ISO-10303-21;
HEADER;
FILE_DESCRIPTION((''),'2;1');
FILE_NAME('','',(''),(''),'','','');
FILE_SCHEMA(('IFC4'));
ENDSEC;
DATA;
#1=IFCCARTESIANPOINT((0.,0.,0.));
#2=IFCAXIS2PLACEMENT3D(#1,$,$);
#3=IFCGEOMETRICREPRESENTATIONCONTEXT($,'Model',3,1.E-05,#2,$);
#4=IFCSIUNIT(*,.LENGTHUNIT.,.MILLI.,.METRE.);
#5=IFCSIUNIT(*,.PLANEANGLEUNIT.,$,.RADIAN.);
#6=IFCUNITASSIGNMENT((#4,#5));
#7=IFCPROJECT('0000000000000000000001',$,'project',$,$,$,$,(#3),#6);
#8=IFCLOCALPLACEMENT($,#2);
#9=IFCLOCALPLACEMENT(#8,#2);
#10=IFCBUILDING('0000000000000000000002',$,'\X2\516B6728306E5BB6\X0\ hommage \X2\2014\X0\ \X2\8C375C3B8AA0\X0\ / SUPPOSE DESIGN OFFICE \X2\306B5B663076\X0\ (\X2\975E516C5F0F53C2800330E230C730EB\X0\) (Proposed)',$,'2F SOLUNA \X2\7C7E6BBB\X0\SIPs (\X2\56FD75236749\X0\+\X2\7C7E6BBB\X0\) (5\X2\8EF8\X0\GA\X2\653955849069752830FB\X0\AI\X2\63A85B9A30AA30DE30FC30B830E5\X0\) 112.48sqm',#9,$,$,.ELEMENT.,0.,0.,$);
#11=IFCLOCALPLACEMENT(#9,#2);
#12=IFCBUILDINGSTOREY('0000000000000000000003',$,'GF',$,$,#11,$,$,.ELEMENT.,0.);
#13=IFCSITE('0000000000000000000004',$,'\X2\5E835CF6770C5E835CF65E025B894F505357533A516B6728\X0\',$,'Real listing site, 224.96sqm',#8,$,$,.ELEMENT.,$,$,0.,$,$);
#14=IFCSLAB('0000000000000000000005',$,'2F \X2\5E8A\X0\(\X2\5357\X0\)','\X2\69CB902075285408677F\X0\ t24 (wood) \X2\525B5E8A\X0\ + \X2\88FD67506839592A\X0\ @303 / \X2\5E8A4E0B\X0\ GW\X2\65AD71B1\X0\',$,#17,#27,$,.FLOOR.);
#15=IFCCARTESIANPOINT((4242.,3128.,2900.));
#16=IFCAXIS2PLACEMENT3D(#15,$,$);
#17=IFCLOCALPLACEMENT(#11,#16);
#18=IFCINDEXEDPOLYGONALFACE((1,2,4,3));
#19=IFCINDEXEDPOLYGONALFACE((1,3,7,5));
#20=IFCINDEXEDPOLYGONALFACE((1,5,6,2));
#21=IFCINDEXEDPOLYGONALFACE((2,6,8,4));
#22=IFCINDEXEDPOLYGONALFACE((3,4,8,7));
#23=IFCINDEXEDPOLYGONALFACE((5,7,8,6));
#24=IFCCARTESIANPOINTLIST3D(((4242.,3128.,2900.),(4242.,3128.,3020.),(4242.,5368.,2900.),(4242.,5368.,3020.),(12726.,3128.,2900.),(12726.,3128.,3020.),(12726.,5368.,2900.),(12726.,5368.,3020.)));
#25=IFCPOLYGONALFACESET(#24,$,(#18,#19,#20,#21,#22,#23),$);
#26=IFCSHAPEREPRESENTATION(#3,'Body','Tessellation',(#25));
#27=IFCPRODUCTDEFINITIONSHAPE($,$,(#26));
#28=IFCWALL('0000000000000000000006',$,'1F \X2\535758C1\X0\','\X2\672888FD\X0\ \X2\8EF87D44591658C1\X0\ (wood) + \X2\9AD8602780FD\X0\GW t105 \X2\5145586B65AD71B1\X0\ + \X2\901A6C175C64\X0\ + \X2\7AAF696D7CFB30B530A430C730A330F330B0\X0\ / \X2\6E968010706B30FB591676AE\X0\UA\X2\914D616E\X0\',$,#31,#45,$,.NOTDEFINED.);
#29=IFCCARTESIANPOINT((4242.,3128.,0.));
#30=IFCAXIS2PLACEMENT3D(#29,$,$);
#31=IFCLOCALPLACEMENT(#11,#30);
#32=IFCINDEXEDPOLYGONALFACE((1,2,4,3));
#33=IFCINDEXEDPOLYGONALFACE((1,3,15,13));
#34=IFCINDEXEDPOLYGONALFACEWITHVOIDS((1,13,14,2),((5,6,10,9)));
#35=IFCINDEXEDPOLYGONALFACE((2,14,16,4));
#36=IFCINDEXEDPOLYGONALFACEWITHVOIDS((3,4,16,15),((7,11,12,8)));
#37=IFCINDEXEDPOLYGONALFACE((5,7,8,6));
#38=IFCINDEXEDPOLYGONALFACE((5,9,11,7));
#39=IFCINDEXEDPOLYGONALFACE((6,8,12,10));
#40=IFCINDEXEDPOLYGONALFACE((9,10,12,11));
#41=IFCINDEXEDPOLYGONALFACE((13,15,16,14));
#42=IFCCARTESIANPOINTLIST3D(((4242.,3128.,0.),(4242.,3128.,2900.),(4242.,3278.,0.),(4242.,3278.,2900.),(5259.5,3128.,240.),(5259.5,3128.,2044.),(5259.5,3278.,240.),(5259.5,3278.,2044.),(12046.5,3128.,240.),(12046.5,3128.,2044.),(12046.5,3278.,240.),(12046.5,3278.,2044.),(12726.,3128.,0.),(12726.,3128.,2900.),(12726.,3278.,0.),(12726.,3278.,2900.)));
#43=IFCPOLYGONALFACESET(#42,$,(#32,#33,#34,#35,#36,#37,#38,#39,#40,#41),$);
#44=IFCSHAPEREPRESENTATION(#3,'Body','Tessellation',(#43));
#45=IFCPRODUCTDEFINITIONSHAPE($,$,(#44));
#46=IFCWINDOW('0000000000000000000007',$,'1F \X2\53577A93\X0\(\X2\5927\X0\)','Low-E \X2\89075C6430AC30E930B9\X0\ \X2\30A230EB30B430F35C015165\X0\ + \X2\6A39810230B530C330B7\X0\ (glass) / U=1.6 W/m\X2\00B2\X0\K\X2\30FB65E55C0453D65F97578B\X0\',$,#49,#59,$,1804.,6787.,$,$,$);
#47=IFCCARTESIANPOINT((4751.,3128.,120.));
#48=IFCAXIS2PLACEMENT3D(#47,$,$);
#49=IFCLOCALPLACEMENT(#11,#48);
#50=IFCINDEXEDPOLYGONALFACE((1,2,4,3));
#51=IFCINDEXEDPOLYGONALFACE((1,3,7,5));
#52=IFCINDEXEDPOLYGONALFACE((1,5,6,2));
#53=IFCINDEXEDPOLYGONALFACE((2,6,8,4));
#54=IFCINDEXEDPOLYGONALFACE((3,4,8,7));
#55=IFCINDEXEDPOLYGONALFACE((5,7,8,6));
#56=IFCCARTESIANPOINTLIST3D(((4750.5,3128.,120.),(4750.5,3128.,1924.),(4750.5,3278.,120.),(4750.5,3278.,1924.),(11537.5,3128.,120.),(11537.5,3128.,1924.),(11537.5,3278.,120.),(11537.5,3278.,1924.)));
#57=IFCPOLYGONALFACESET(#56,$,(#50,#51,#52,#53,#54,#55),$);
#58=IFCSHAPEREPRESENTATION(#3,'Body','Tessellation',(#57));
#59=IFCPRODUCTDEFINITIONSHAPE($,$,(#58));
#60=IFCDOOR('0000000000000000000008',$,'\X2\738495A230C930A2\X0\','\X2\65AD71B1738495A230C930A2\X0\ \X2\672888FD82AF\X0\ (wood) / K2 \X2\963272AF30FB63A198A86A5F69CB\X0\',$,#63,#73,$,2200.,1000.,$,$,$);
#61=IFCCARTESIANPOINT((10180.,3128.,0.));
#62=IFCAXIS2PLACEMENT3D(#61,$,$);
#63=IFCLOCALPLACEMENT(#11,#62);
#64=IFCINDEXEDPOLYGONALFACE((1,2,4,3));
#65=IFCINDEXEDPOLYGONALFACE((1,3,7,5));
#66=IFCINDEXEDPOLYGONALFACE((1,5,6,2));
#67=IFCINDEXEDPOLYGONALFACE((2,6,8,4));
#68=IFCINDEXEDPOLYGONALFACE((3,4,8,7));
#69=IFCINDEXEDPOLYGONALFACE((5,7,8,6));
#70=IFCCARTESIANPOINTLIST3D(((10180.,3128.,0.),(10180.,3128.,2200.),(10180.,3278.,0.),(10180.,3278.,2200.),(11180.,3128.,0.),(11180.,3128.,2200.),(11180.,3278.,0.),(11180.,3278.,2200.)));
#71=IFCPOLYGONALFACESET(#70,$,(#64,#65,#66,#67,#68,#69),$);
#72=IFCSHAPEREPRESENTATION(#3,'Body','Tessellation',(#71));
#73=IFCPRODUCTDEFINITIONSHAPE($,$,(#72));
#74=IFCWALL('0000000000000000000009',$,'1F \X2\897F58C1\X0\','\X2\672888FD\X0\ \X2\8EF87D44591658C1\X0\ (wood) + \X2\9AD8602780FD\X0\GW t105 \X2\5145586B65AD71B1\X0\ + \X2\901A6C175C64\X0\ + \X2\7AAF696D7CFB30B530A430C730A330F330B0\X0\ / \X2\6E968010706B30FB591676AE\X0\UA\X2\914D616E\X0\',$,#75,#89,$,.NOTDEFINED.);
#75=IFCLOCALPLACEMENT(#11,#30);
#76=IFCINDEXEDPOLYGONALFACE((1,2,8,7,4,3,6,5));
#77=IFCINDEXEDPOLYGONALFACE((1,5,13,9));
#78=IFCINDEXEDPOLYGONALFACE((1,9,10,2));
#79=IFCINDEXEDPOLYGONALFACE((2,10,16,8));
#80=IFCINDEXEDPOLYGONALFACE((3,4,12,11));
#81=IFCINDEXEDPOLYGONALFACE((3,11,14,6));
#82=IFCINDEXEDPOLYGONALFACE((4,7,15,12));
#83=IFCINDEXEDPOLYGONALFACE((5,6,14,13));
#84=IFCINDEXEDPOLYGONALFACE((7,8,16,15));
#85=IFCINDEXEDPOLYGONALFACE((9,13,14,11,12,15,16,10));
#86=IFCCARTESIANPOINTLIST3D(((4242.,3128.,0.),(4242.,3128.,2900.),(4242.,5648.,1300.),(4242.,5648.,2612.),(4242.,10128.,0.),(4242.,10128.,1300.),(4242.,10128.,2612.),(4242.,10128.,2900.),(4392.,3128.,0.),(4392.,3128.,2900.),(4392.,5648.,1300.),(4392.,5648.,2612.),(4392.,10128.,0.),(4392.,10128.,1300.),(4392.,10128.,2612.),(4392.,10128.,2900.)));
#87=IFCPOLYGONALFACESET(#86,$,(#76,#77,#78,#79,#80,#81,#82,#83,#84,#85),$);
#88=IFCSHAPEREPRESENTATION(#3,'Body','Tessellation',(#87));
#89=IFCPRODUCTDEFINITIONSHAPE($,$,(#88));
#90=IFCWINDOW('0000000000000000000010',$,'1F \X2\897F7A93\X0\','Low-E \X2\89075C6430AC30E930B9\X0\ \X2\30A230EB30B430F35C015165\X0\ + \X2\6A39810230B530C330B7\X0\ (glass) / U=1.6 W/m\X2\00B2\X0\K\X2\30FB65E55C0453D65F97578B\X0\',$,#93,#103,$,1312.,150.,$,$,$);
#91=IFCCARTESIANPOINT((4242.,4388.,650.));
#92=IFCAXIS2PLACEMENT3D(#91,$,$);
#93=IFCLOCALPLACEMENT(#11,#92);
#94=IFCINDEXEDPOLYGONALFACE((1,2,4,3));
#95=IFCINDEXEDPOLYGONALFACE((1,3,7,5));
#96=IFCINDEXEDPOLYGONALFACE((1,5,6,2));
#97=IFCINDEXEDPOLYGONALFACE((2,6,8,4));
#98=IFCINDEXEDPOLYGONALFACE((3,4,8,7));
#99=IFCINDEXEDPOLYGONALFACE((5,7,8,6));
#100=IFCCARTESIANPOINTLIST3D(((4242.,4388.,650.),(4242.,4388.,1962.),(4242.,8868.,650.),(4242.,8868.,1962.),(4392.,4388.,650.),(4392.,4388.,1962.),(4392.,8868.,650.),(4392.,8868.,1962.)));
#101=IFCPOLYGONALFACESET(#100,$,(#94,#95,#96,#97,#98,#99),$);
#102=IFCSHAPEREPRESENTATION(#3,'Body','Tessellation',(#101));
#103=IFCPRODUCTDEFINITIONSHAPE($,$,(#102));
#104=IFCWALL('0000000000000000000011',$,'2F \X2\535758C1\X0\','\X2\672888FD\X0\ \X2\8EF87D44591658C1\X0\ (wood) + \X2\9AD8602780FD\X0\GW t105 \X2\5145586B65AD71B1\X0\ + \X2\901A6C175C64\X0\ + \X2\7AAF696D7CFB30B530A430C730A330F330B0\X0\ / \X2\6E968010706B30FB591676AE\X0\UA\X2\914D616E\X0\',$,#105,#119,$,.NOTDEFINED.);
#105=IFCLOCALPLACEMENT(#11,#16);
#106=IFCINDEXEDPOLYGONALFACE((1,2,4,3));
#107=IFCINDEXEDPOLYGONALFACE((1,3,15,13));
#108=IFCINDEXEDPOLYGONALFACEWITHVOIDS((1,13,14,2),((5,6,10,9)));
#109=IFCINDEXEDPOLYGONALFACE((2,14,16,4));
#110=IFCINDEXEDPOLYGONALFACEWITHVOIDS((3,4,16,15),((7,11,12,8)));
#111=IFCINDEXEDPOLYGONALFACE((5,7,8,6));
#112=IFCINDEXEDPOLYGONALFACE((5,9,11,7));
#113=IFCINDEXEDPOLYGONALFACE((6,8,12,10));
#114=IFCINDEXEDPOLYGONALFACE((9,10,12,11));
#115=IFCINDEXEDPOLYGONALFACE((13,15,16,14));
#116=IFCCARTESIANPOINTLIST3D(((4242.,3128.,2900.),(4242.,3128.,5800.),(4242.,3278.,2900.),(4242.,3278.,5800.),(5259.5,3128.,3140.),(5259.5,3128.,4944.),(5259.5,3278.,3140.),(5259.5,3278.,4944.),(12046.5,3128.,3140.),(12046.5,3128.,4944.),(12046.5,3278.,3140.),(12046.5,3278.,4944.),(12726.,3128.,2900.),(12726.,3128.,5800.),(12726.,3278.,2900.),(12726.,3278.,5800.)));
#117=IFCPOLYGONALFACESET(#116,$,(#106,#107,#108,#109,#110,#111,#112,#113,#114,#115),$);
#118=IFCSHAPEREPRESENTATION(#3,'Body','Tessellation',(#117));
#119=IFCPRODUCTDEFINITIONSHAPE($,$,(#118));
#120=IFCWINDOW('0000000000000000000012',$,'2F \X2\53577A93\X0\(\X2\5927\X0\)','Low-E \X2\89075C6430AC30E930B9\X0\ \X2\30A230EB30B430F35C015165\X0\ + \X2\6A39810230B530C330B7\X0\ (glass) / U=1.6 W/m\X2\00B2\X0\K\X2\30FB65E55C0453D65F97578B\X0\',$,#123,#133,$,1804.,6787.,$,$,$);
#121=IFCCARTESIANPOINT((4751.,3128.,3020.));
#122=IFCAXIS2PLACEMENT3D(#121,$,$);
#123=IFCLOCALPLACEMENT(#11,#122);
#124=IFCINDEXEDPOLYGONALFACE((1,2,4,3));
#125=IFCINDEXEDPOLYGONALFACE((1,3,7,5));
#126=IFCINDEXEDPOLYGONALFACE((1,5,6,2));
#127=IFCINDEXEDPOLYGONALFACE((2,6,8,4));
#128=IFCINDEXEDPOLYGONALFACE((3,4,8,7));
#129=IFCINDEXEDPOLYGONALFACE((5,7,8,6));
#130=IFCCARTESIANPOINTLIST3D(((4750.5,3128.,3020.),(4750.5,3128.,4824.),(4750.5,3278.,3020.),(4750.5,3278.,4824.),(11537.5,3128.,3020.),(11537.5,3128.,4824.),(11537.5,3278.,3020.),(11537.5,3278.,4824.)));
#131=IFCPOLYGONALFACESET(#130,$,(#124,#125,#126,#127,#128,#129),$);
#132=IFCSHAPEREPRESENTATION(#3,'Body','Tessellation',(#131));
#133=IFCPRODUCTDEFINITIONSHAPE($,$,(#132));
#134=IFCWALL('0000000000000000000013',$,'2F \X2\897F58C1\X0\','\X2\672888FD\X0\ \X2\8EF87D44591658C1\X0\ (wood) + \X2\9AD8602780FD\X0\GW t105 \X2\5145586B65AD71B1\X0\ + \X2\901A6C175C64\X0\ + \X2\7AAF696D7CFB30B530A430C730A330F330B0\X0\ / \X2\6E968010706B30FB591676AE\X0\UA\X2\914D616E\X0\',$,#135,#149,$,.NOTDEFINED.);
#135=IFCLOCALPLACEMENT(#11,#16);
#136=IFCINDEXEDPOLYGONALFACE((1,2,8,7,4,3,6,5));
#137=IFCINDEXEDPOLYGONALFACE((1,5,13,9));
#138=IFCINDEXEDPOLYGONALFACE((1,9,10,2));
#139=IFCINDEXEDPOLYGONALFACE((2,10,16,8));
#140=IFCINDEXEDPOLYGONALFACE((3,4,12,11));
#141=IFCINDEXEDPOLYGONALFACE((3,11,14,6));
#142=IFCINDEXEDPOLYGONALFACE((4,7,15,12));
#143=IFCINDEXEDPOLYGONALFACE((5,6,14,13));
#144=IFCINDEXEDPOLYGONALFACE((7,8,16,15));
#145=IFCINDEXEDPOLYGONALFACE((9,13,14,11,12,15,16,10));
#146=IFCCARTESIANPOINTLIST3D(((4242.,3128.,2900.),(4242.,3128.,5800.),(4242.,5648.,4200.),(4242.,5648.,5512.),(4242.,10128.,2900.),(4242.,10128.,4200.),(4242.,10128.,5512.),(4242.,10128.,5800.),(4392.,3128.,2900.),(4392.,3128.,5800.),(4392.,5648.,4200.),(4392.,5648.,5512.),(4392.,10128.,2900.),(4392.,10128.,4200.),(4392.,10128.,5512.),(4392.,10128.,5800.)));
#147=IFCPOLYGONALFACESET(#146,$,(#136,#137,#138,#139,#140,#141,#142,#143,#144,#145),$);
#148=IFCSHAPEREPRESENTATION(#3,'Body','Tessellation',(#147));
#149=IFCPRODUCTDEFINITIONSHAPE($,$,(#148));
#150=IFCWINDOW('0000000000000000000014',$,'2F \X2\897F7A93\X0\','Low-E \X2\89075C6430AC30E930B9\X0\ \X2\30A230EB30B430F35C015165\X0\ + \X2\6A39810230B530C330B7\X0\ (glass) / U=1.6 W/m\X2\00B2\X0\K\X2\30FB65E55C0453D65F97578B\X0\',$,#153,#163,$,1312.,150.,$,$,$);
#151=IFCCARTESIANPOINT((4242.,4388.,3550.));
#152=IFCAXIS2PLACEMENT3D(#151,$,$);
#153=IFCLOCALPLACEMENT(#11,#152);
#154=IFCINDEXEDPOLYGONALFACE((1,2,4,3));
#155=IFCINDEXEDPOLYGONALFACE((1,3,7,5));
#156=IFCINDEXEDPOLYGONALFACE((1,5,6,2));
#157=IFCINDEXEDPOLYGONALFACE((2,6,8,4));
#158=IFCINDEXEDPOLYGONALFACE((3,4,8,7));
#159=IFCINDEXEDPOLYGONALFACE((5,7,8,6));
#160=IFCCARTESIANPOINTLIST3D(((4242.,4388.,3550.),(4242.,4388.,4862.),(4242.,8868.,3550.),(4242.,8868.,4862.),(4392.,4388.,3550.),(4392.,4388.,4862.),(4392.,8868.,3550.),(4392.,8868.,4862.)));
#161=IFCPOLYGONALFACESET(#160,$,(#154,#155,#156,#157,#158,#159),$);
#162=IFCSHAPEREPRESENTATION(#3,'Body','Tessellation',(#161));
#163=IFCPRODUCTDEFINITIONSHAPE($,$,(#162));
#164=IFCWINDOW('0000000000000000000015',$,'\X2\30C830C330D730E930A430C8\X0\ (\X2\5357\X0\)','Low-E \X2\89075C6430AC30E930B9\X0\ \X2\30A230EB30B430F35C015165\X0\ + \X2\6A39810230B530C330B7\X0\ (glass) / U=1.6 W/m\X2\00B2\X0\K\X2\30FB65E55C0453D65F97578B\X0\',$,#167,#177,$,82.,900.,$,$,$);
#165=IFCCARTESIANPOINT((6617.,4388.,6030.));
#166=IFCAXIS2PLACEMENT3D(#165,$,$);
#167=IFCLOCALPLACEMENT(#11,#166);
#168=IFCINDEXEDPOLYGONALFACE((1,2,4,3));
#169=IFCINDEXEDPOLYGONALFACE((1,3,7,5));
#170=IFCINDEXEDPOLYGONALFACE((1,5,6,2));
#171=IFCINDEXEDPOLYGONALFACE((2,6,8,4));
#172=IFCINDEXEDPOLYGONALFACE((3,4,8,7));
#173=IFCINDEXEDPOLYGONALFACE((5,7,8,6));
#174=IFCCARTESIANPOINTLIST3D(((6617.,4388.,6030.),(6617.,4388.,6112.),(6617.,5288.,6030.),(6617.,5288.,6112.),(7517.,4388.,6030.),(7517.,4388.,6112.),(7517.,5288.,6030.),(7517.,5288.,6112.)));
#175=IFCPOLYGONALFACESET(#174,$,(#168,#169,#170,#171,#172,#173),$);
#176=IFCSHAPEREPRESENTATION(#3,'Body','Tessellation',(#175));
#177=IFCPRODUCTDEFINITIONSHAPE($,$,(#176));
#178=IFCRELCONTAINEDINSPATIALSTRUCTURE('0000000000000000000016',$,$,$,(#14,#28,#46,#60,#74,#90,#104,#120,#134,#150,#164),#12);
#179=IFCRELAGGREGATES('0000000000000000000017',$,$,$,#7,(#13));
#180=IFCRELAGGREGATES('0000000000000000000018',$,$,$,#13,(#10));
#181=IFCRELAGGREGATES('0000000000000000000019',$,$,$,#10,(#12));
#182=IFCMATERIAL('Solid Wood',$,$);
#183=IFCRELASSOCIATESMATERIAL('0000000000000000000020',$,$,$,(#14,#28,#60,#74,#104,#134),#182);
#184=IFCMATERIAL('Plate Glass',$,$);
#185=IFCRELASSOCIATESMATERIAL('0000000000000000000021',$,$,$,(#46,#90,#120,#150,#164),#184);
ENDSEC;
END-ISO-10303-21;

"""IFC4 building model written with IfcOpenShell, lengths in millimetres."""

from ifc_helpers import new_model, si_unit, frame, frame_2d, origin, place, context, project, spatial, rectangle, extrude, material, element, fill, save


model = new_model("IFC4")

# Units and contexts
model_context = context("Model", 3, precision=1e-05, world=origin())
ifc_project = project(units=[si_unit("LENGTHUNIT", "METRE", prefix="MILLI"), si_unit("PLANEANGLEUNIT", "RADIAN")], contexts=[model_context])

# Site, building, storey
site_placement = place(None, origin())
site = spatial("IfcSite", under=ifc_project, at=site_placement, Name="広島県広島市安佐南区八木", ObjectType="Real listing site, 224.96sqm", CompositionType="ELEMENT", RefElevation=0.0)
building_placement = place(site_placement, origin())
building = spatial("IfcBuilding", under=site, at=building_placement, Name="八木の家 hommage — 谷尻誠 / SUPPOSE DESIGN OFFICE に学ぶ (非公式参考モデル) (Proposed)", ObjectType="2F SOLUNA 籾殻SIPs (国産杉+籾殻) (5軸GA改善適用・AI推定オマージュ) 112.48sqm", CompositionType="ELEMENT", ElevationOfRefHeight=0.0, ElevationOfTerrain=0.0)
storey_placement = place(building_placement, origin())
storey = spatial("IfcBuildingStorey", under=building, at=storey_placement, Name="GF", CompositionType="ELEMENT", Elevation=0.0)

# Slab
ifc_material_1 = material(Name="Solid Wood")
slab_1_placement = place(storey_placement, frame((4242.0, 3128.0, 2900.0)))
element("IfcSlab", 1, at=slab_1_placement, inside=storey, material=ifc_material_1, Name="2F 床(南)", Description="構造用合板 t24 (wood) 剛床 + 製材根太 @303 / 床下 GW断熱", PredefinedType="FLOOR", context=model_context, shape_type="SweptSolid", body=[
    extrude(rectangle(XDim=8484.0, YDim=2240.0, at=frame_2d((4242.0, 1120.0))), frame((4242.0, 3128.0, 2900.0)), (0.0, 0.0, 1.0), 120.0),
])

# Wall, openings, window, door
wall_1_placement = place(storey_placement, frame((4242.0, 3128.0, 0.0)))
wall_1 = element("IfcWall", 2, at=wall_1_placement, inside=storey, material=ifc_material_1, Name="1F 南壁", Description="木製 軸組外壁 (wood) + 高性能GW t105 充填断熱 + 通気層 + 窯業系サイディング / 準耐火・外皮UA配慮", PredefinedType="NOTDEFINED", context=model_context, shape_type="SweptSolid", body=[
    extrude(rectangle(XDim=8484.0, YDim=150.0, at=frame_2d((4242.0, 75.0))), frame((4242.0, 3128.0, 0.0)), (0.0, 0.0, 1.0), 2900.0),
])
opening_1_placement = place(storey_placement, frame((4751.0, 3128.0, 120.0)))
opening_1 = element("IfcOpeningElement", 3, at=opening_1_placement, cuts=wall_1, PredefinedType="NOTDEFINED", context=model_context, shape_type="SweptSolid", body=[
    extrude(rectangle(XDim=6787.0, YDim=150.0, at=frame_2d((3393.0, 75.0))), frame((4751.0, 3128.0, 120.0)), (0.0, 0.0, 1.0), 1804.0),
])
opening_2_placement = place(storey_placement, frame((10180.0, 3128.0, 0.0)))
opening_2 = element("IfcOpeningElement", 4, at=opening_2_placement, cuts=wall_1, PredefinedType="NOTDEFINED", context=model_context, shape_type="SweptSolid", body=[
    extrude(rectangle(XDim=1000.0, YDim=150.0, at=frame_2d((500.0, 75.0))), frame((10180.0, 3128.0, 0.0)), (0.0, 0.0, 1.0), 2200.0),
])
ifc_material_2 = material(Name="Plate Glass")
window_1_placement = place(storey_placement, frame((4751.0, 3128.0, 120.0)))
window_1 = element("IfcWindow", 5, at=window_1_placement, inside=storey, material=ifc_material_2, Name="1F 南窓(大)", Description="Low-E 複層ガラス アルゴン封入 + 樹脂サッシ (glass) / U=1.6 W/m²K・日射取得型", OverallHeight=1804.0, OverallWidth=6787.0, context=model_context, shape_type="SweptSolid", body=[
    extrude(rectangle(XDim=6787.0, YDim=150.0, at=frame_2d((3393.0, 75.0))), frame((4751.0, 3128.0, 120.0)), (0.0, 0.0, 1.0), 1804.0),
])
fill(opening_1, window_1)
door_placement = place(storey_placement, frame((10180.0, 3128.0, 0.0)))
door = element("IfcDoor", 6, at=door_placement, inside=storey, material=ifc_material_1, Name="玄関ドア", Description="断熱玄関ドア 木製芯 (wood) / K2 防犯・採風機構", OverallHeight=2200.0, OverallWidth=1000.0, context=model_context, shape_type="SweptSolid", body=[
    extrude(rectangle(XDim=1000.0, YDim=150.0, at=frame_2d((500.0, 75.0))), frame((10180.0, 3128.0, 0.0)), (0.0, 0.0, 1.0), 2200.0),
])
fill(opening_2, door)

# Walls, openings, windows
wall_2_placement = place(storey_placement, frame((4242.0, 3128.0, 0.0)))
wall_2 = element("IfcWall", 7, at=wall_2_placement, inside=storey, material=ifc_material_1, Name="1F 西壁", Description="木製 軸組外壁 (wood) + 高性能GW t105 充填断熱 + 通気層 + 窯業系サイディング / 準耐火・外皮UA配慮", PredefinedType="NOTDEFINED", context=model_context, shape_type="SweptSolid", body=[
    extrude(rectangle(XDim=150.0, YDim=7000.0, at=frame_2d((75.0, 3500.0))), frame((4242.0, 3128.0, 0.0)), (0.0, 0.0, 1.0), 2900.0),
])
opening_3_placement = place(storey_placement, frame((4242.0, 4388.0, 650.0)))
opening_3 = element("IfcOpeningElement", 8, at=opening_3_placement, cuts=wall_2, PredefinedType="NOTDEFINED", context=model_context, shape_type="SweptSolid", body=[
    extrude(rectangle(XDim=150.0, YDim=4480.0, at=frame_2d((75.0, 2240.0))), frame((4242.0, 4388.0, 650.0)), (0.0, 0.0, 1.0), 1312.0),
])
window_2_placement = place(storey_placement, frame((4242.0, 4388.0, 650.0)))
window_2 = element("IfcWindow", 9, at=window_2_placement, inside=storey, material=ifc_material_2, Name="1F 西窓", Description="Low-E 複層ガラス アルゴン封入 + 樹脂サッシ (glass) / U=1.6 W/m²K・日射取得型", OverallHeight=1312.0, OverallWidth=150.0, context=model_context, shape_type="SweptSolid", body=[
    extrude(rectangle(XDim=150.0, YDim=4480.0, at=frame_2d((75.0, 2240.0))), frame((4242.0, 4388.0, 650.0)), (0.0, 0.0, 1.0), 1312.0),
])
fill(opening_3, window_2)
wall_3_placement = place(storey_placement, frame((4242.0, 3128.0, 2900.0)))
wall_3 = element("IfcWall", 10, at=wall_3_placement, inside=storey, material=ifc_material_1, Name="2F 南壁", Description="木製 軸組外壁 (wood) + 高性能GW t105 充填断熱 + 通気層 + 窯業系サイディング / 準耐火・外皮UA配慮", PredefinedType="NOTDEFINED", context=model_context, shape_type="SweptSolid", body=[
    extrude(rectangle(XDim=8484.0, YDim=150.0, at=frame_2d((4242.0, 75.0))), frame((4242.0, 3128.0, 2900.0)), (0.0, 0.0, 1.0), 2900.0),
])
opening_4_placement = place(storey_placement, frame((4751.0, 3128.0, 3020.0)))
opening_4 = element("IfcOpeningElement", 11, at=opening_4_placement, cuts=wall_3, PredefinedType="NOTDEFINED", context=model_context, shape_type="SweptSolid", body=[
    extrude(rectangle(XDim=6787.0, YDim=150.0, at=frame_2d((3393.0, 75.0))), frame((4751.0, 3128.0, 3020.0)), (0.0, 0.0, 1.0), 1804.0),
])
window_3_placement = place(storey_placement, frame((4751.0, 3128.0, 3020.0)))
window_3 = element("IfcWindow", 12, at=window_3_placement, inside=storey, material=ifc_material_2, Name="2F 南窓(大)", Description="Low-E 複層ガラス アルゴン封入 + 樹脂サッシ (glass) / U=1.6 W/m²K・日射取得型", OverallHeight=1804.0, OverallWidth=6787.0, context=model_context, shape_type="SweptSolid", body=[
    extrude(rectangle(XDim=6787.0, YDim=150.0, at=frame_2d((3393.0, 75.0))), frame((4751.0, 3128.0, 3020.0)), (0.0, 0.0, 1.0), 1804.0),
])
fill(opening_4, window_3)
wall_4_placement = place(storey_placement, frame((4242.0, 3128.0, 2900.0)))
wall_4 = element("IfcWall", 13, at=wall_4_placement, inside=storey, material=ifc_material_1, Name="2F 西壁", Description="木製 軸組外壁 (wood) + 高性能GW t105 充填断熱 + 通気層 + 窯業系サイディング / 準耐火・外皮UA配慮", PredefinedType="NOTDEFINED", context=model_context, shape_type="SweptSolid", body=[
    extrude(rectangle(XDim=150.0, YDim=7000.0, at=frame_2d((75.0, 3500.0))), frame((4242.0, 3128.0, 2900.0)), (0.0, 0.0, 1.0), 2900.0),
])
opening_5_placement = place(storey_placement, frame((4242.0, 4388.0, 3550.0)))
opening_5 = element("IfcOpeningElement", 14, at=opening_5_placement, cuts=wall_4, PredefinedType="NOTDEFINED", context=model_context, shape_type="SweptSolid", body=[
    extrude(rectangle(XDim=150.0, YDim=4480.0, at=frame_2d((75.0, 2240.0))), frame((4242.0, 4388.0, 3550.0)), (0.0, 0.0, 1.0), 1312.0),
])
window_4_placement = place(storey_placement, frame((4242.0, 4388.0, 3550.0)))
window_4 = element("IfcWindow", 15, at=window_4_placement, inside=storey, material=ifc_material_2, Name="2F 西窓", Description="Low-E 複層ガラス アルゴン封入 + 樹脂サッシ (glass) / U=1.6 W/m²K・日射取得型", OverallHeight=1312.0, OverallWidth=150.0, context=model_context, shape_type="SweptSolid", body=[
    extrude(rectangle(XDim=150.0, YDim=4480.0, at=frame_2d((75.0, 2240.0))), frame((4242.0, 4388.0, 3550.0)), (0.0, 0.0, 1.0), 1312.0),
])
fill(opening_5, window_4)

# Window
window_5_placement = place(storey_placement, frame((6617.0, 4388.0, 6030.0)))
element("IfcWindow", 16, at=window_5_placement, inside=storey, material=ifc_material_2, Name="トップライト (南)", Description="Low-E 複層ガラス アルゴン封入 + 樹脂サッシ (glass) / U=1.6 W/m²K・日射取得型", OverallHeight=82.0, OverallWidth=900.0, context=model_context, shape_type="SweptSolid", body=[
    extrude(rectangle(XDim=900.0, YDim=900.0, at=frame_2d((450.0, 450.0))), frame((6617.0, 4388.0, 6030.0)), (0.0, 0.0, 1.0), 82.0),
])

save(model, "model.ifc")
